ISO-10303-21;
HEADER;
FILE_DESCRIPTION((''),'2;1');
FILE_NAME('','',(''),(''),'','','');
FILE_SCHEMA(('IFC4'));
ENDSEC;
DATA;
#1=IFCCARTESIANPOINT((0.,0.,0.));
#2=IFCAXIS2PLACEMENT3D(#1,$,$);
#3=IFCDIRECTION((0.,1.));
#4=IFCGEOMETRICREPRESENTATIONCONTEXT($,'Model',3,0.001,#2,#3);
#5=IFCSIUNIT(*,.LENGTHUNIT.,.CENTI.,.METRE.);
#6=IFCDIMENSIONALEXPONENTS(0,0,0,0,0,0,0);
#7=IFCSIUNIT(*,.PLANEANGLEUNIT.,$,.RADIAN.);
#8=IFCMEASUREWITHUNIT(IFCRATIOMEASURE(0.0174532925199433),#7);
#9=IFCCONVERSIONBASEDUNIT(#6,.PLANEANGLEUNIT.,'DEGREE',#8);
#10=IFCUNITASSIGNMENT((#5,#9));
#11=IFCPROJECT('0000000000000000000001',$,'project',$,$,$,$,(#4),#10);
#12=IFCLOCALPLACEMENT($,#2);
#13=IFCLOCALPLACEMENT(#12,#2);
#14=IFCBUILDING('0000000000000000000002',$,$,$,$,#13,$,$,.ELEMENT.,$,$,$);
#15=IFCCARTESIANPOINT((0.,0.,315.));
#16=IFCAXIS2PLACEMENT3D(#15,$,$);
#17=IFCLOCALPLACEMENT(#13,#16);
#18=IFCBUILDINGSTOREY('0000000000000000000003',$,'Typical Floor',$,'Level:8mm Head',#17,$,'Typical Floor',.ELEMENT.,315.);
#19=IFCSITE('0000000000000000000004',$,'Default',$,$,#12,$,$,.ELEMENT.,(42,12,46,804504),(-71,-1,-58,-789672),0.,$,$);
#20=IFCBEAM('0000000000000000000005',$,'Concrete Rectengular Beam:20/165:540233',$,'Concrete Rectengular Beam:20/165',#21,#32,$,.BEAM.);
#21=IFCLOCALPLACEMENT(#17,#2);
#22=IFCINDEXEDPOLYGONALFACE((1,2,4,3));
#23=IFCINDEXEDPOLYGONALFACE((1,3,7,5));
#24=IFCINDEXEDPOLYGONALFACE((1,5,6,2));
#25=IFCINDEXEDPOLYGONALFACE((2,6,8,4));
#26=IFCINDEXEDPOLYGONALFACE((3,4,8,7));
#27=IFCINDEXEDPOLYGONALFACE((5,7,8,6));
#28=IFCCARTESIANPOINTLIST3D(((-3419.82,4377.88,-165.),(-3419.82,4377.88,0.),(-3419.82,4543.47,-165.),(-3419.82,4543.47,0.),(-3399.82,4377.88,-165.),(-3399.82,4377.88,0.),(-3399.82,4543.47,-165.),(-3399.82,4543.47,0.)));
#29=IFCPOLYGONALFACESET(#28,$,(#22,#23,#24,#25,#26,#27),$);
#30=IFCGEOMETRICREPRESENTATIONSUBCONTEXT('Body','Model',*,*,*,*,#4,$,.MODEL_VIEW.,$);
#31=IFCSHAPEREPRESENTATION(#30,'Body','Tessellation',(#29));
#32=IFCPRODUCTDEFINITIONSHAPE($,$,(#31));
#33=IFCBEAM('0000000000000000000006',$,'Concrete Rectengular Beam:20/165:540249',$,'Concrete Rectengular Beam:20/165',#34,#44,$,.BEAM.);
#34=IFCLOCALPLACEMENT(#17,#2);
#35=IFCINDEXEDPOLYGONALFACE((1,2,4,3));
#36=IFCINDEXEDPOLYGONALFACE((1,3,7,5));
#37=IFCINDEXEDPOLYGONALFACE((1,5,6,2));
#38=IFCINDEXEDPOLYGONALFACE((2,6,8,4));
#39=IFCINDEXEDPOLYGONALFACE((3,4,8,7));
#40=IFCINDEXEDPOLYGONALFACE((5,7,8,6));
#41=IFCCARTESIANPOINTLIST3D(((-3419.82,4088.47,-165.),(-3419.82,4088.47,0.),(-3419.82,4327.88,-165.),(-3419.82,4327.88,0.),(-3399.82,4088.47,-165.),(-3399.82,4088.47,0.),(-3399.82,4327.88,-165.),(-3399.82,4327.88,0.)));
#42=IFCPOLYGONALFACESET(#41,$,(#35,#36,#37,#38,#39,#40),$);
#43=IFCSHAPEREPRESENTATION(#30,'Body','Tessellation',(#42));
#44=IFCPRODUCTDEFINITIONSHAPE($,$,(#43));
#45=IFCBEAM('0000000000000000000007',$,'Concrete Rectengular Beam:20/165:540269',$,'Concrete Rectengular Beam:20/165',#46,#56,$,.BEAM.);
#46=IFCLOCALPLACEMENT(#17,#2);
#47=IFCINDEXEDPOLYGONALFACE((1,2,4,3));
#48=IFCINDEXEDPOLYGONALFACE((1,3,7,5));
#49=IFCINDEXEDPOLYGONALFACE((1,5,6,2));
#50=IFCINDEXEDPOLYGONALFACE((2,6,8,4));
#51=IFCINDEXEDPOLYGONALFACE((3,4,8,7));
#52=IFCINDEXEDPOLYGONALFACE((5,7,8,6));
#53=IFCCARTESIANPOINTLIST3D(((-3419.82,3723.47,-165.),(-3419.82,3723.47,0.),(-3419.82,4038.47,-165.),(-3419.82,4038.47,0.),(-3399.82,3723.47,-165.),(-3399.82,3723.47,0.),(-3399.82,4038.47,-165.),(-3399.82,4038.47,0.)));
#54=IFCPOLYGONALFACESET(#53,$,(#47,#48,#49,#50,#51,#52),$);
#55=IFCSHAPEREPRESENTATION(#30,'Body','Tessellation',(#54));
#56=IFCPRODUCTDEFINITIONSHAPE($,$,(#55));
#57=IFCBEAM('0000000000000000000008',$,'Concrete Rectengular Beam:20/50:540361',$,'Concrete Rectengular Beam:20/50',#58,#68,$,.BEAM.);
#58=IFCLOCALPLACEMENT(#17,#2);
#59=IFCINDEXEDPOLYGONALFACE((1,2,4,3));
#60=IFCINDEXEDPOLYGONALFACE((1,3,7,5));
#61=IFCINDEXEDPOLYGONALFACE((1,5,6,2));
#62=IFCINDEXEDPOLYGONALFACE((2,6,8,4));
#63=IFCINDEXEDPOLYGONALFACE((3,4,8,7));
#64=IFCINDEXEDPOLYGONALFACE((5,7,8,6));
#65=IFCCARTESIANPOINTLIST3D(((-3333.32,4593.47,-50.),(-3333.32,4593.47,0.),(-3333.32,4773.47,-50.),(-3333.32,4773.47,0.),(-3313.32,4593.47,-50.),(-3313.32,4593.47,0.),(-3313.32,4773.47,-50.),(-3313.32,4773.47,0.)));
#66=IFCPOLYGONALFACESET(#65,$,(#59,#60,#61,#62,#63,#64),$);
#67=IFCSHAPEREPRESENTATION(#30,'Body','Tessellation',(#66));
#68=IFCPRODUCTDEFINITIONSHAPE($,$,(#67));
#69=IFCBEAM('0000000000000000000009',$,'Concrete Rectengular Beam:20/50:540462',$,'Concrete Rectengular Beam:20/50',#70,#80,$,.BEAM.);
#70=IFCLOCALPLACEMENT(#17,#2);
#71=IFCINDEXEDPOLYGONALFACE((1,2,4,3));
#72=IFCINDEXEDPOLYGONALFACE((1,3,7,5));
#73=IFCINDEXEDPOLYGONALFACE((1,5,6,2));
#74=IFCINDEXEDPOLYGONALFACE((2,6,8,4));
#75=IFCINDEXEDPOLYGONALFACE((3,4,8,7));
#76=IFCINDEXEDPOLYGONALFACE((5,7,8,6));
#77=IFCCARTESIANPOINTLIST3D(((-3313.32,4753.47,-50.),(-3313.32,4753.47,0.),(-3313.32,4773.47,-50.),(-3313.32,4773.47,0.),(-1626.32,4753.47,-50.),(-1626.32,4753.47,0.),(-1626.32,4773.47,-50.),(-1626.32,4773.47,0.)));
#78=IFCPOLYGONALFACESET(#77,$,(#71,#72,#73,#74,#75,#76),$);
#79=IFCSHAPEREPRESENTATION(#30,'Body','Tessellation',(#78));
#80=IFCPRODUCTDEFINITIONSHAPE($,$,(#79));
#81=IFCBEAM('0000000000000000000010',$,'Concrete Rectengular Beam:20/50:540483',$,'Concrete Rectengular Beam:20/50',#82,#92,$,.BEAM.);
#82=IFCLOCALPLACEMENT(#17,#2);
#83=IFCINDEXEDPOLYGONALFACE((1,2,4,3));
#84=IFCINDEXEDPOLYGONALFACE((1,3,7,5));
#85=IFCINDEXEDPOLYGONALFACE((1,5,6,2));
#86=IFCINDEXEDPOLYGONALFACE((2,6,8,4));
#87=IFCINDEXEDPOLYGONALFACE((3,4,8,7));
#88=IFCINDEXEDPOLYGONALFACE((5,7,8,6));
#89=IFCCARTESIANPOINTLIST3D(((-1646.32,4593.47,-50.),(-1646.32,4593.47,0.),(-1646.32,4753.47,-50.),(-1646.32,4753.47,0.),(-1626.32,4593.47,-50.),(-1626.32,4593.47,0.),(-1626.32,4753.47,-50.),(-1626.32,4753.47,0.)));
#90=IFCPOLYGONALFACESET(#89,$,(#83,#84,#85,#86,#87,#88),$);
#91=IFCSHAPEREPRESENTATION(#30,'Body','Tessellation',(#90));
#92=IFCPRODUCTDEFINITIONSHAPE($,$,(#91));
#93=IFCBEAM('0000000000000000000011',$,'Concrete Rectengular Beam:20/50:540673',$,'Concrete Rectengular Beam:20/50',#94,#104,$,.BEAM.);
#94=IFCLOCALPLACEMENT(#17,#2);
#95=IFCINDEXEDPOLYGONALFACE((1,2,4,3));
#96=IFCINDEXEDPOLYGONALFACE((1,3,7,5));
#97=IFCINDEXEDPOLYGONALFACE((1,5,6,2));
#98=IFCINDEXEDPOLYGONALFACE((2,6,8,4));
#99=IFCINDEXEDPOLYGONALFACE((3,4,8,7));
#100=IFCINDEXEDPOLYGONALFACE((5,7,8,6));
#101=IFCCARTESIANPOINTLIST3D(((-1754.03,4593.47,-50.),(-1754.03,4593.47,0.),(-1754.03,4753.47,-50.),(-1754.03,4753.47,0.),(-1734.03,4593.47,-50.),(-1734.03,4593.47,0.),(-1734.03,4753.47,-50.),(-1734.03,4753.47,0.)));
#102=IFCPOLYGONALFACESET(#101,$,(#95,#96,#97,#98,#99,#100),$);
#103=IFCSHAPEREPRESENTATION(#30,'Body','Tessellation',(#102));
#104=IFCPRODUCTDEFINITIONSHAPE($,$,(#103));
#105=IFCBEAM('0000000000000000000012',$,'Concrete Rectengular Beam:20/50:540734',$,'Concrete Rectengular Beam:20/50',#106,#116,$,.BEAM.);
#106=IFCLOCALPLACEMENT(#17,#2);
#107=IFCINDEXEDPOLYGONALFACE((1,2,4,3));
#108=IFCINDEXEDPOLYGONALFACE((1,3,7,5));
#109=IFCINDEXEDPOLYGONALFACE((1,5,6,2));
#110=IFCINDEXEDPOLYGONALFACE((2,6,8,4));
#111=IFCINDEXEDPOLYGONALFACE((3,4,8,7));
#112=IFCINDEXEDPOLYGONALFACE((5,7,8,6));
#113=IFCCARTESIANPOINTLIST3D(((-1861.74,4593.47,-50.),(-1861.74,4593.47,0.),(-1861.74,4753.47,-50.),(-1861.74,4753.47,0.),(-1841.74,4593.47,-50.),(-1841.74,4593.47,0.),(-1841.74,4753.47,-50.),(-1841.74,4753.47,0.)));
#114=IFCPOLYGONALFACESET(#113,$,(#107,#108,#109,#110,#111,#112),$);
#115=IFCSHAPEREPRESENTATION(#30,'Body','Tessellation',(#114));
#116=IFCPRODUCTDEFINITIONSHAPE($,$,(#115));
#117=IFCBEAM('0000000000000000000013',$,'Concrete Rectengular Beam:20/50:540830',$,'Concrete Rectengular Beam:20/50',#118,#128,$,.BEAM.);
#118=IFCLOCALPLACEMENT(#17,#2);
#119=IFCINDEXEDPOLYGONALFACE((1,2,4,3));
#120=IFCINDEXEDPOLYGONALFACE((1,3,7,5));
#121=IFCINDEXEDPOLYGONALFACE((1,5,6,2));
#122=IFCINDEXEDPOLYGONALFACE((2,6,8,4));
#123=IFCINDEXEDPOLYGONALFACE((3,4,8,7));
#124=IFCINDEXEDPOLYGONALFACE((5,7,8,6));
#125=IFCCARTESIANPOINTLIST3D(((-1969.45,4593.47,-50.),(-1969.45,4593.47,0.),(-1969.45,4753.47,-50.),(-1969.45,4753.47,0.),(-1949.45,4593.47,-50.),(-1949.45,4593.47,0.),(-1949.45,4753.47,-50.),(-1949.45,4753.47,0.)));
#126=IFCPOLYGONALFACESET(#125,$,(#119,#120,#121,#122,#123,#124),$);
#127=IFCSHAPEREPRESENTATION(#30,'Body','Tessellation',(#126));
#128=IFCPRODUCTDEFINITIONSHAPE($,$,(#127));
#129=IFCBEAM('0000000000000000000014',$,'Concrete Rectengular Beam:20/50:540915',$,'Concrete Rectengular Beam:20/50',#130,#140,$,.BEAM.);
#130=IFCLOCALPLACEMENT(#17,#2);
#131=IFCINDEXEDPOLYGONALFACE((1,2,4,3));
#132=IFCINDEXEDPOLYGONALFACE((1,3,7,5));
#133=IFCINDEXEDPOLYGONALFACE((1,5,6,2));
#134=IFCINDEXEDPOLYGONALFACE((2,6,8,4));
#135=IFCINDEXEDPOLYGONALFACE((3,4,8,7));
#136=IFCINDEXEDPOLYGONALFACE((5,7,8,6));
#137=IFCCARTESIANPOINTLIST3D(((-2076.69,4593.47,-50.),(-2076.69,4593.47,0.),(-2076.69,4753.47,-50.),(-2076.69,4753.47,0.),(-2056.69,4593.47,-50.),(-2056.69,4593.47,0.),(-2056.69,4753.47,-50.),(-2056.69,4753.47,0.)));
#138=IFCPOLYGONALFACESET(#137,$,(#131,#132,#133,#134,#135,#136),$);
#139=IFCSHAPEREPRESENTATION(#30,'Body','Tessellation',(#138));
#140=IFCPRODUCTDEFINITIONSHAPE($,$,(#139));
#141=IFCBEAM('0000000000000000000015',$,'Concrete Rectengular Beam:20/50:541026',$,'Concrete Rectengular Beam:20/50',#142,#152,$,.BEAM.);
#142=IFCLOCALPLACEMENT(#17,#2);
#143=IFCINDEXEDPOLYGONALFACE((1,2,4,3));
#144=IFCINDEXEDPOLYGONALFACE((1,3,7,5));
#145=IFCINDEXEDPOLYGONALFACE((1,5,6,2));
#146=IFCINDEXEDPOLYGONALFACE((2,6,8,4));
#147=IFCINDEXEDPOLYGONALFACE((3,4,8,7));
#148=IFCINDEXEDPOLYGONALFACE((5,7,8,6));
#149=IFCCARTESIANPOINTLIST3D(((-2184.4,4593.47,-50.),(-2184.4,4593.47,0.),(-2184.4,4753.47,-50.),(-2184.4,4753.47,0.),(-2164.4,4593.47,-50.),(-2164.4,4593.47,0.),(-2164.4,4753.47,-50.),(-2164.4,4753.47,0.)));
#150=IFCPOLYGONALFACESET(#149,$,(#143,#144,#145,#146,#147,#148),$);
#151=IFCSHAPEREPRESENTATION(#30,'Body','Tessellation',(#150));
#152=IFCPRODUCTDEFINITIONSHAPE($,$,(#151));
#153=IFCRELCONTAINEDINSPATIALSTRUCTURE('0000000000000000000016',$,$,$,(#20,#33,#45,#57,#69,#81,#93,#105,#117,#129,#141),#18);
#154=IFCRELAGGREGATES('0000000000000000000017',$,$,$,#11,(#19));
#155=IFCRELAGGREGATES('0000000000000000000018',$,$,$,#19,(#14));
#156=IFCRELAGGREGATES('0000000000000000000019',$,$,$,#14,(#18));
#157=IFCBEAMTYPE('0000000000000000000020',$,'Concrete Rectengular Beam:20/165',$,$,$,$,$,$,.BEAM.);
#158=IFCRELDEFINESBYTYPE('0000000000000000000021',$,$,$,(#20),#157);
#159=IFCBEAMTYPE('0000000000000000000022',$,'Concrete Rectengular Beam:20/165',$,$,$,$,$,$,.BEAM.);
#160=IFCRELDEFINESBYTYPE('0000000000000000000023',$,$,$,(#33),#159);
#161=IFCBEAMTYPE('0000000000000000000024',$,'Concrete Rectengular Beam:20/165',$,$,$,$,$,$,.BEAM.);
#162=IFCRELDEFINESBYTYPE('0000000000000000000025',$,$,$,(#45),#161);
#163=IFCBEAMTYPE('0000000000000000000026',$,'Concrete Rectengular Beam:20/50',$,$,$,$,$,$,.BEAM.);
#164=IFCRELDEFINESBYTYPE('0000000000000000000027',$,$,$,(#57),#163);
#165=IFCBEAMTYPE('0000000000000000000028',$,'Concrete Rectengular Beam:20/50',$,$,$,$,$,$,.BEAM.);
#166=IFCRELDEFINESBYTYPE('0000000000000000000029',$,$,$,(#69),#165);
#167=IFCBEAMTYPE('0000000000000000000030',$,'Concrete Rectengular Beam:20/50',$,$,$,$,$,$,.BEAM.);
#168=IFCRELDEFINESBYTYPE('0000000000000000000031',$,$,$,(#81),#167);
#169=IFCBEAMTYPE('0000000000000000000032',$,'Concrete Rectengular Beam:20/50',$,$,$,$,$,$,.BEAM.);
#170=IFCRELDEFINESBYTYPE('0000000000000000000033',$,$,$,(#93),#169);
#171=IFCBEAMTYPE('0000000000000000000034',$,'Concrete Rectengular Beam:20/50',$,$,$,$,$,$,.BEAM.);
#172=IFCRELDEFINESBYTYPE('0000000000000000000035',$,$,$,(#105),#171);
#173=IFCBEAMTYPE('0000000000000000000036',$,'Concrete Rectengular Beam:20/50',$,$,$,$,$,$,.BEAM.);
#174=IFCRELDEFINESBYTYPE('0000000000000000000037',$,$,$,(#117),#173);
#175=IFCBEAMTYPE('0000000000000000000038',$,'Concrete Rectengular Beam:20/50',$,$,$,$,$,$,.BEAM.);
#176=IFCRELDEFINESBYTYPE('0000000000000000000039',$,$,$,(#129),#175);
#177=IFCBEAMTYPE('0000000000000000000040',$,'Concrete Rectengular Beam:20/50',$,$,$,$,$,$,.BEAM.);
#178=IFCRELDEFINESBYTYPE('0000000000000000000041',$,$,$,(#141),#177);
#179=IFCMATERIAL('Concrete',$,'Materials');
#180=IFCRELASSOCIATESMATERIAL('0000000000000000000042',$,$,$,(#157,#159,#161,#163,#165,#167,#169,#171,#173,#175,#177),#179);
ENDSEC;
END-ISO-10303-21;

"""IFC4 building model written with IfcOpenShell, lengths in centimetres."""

from ifc_helpers import new_model, entity, si_unit, converted_unit, direction, frame, origin, place, context, subcontext, project, spatial, indexed_curve, outline, extrude, source, transform, mapped, material, type_object, type_shapes, element, save


model = new_model("IFC4")

# Units and contexts
model_context = context("Model", 3, precision=0.001, world=origin(), true_north=direction((0.0, 1.0)))
body_context = subcontext(model_context, "Body", "Model", "MODEL_VIEW")
ifc_project = project(units=[si_unit("LENGTHUNIT", "METRE", prefix="CENTI"), converted_unit("PLANEANGLEUNIT", "DEGREE", entity("IfcRatioMeasure", 0.0174532925199433), si_unit("PLANEANGLEUNIT", "RADIAN"), dimensions=[0, 0, 0, 0, 0, 0, 0])], contexts=[model_context])

# Site, building, storey
site_placement = place(None, origin())
site = spatial("IfcSite", under=ifc_project, at=site_placement, Name="Default", CompositionType="ELEMENT", RefLatitude=(42, 12, 46, 804504), RefLongitude=(-71, -1, -58, -789672), RefElevation=0.0)
building_placement = place(site_placement, origin())
building = spatial("IfcBuilding", under=site, at=building_placement, CompositionType="ELEMENT")
storey_placement = place(building_placement, frame((0.0, 0.0, 315.0)))
storey = spatial("IfcBuildingStorey", under=building, at=storey_placement, Name="Typical Floor", ObjectType="Level:8mm Head", LongName="Typical Floor", CompositionType="ELEMENT", Elevation=315.0)

# Beams
ifc_material = material(Name="Concrete", Category="Materials")
beam_type_1 = type_object("IfcBeamType", Name="Concrete Rectengular Beam:20/165", PredefinedType="BEAM", material=ifc_material)
shared_shape_1 = source(origin(), body_context, "Body", "SweptSolid", [
    extrude(outline(indexed_curve([(-10.0, -82.5), (10.0, -82.5), (10.0, 82.5), (-10.0, 82.5), (-10.0, -82.5)], self_intersect=False)), frame((-3409.82, 4543.47, 232.5), z_axis=(0.0, -1.0, 0.0), x_axis=(-1.0, 0.0, 0.0)), (0.0, 0.0, 1.0), 165.59),
])
type_shapes(beam_type_1, [shared_shape_1])
beam_1_placement = place(storey_placement, frame((0.0, 0.0, -315.0)))
element("IfcBeam", 1, at=beam_1_placement, inside=storey, type_object=beam_type_1, Name="Concrete Rectengular Beam:20/165:540233", ObjectType="Concrete Rectengular Beam:20/165", PredefinedType="BEAM", context=body_context, shape_type="MappedRepresentation", body=[
    mapped(shared_shape_1, transform((0.0, 0.0, 0.0), scale=1.0)),
])
beam_type_2 = type_object("IfcBeamType", Name="Concrete Rectengular Beam:20/165", PredefinedType="BEAM", material=ifc_material)
shared_shape_2 = source(origin(), body_context, "Body", "SweptSolid", [
    extrude(outline(indexed_curve([(-10.0, -82.5), (10.0, -82.5), (10.0, 82.5), (-10.0, 82.5), (-10.0, -82.5)], self_intersect=False)), frame((-3409.82, 4327.88, 232.5), z_axis=(0.0, -1.0, 0.0), x_axis=(-1.0, 0.0, 0.0)), (0.0, 0.0, 1.0), 239.41),
])
type_shapes(beam_type_2, [shared_shape_2])
beam_2_placement = place(storey_placement, frame((0.0, 0.0, -315.0)))
element("IfcBeam", 2, at=beam_2_placement, inside=storey, type_object=beam_type_2, Name="Concrete Rectengular Beam:20/165:540249", ObjectType="Concrete Rectengular Beam:20/165", PredefinedType="BEAM", context=body_context, shape_type="MappedRepresentation", body=[
    mapped(shared_shape_2, transform((0.0, 0.0, 0.0), scale=1.0)),
])
beam_type_3 = type_object("IfcBeamType", Name="Concrete Rectengular Beam:20/165", PredefinedType="BEAM", material=ifc_material)
shared_shape_3 = source(origin(), body_context, "Body", "SweptSolid", [
    extrude(outline(indexed_curve([(-10.0, -82.5), (10.0, -82.5), (10.0, 82.5), (-10.0, 82.5), (-10.0, -82.5)], self_intersect=False)), frame((-3409.82, 4038.47, 232.5), z_axis=(0.0, -1.0, 0.0), x_axis=(-1.0, 0.0, 0.0)), (0.0, 0.0, 1.0), 315.0),
])
type_shapes(beam_type_3, [shared_shape_3])
beam_3_placement = place(storey_placement, frame((0.0, 0.0, -315.0)))
element("IfcBeam", 3, at=beam_3_placement, inside=storey, type_object=beam_type_3, Name="Concrete Rectengular Beam:20/165:540269", ObjectType="Concrete Rectengular Beam:20/165", PredefinedType="BEAM", context=body_context, shape_type="MappedRepresentation", body=[
    mapped(shared_shape_3, transform((0.0, 0.0, 0.0), scale=1.0)),
])
beam_type_4 = type_object("IfcBeamType", Name="Concrete Rectengular Beam:20/50", PredefinedType="BEAM", material=ifc_material)
shared_shape_4 = source(origin(), body_context, "Body", "SweptSolid", [
    extrude(outline(indexed_curve([(-10.0, -25.0), (10.0, -25.0), (10.0, 25.0), (-10.0, 25.0), (-10.0, -25.0)], self_intersect=False)), frame((-3323.32, 4593.47, 290.0), z_axis=(0.0, 1.0, 0.0), x_axis=(-1.0, 0.0, 0.0)), (0.0, 0.0, 1.0), 180.0),
])
type_shapes(beam_type_4, [shared_shape_4])
beam_4_placement = place(storey_placement, frame((0.0, 0.0, -315.0)))
element("IfcBeam", 4, at=beam_4_placement, inside=storey, type_object=beam_type_4, Name="Concrete Rectengular Beam:20/50:540361", ObjectType="Concrete Rectengular Beam:20/50", PredefinedType="BEAM", context=body_context, shape_type="MappedRepresentation", body=[
    mapped(shared_shape_4, transform((0.0, 0.0, 0.0), scale=1.0)),
])
beam_type_5 = type_object("IfcBeamType", Name="Concrete Rectengular Beam:20/50", PredefinedType="BEAM", material=ifc_material)
shared_shape_5 = source(origin(), body_context, "Body", "SweptSolid", [
    extrude(outline(indexed_curve([(-25.0, -10.0), (25.0, -10.0), (25.0, 10.0), (-25.0, 10.0), (-25.0, -10.0)], self_intersect=False)), frame((-3313.32, 4763.47, 290.0), z_axis=(1.0, 0.0, 0.0), x_axis=(0.0, 0.0, -1.0)), (0.0, 0.0, 1.0), 1687.0),
])
type_shapes(beam_type_5, [shared_shape_5])
beam_5_placement = place(storey_placement, frame((0.0, 0.0, -315.0)))
element("IfcBeam", 5, at=beam_5_placement, inside=storey, type_object=beam_type_5, Name="Concrete Rectengular Beam:20/50:540462", ObjectType="Concrete Rectengular Beam:20/50", PredefinedType="BEAM", context=body_context, shape_type="MappedRepresentation", body=[
    mapped(shared_shape_5, transform((0.0, 0.0, 0.0), scale=1.0)),
])
beam_type_6 = type_object("IfcBeamType", Name="Concrete Rectengular Beam:20/50", PredefinedType="BEAM", material=ifc_material)
shared_shape_6 = source(origin(), body_context, "Body", "SweptSolid", [
    extrude(outline(indexed_curve([(-10.0, -25.0), (10.0, -25.0), (10.0, 25.0), (-10.0, 25.0), (-10.0, -25.0)], self_intersect=False)), frame((-1636.32, 4753.47, 290.0), z_axis=(0.0, -1.0, 0.0), x_axis=(-1.0, 0.0, 0.0)), (0.0, 0.0, 1.0), 160.0),
])
type_shapes(beam_type_6, [shared_shape_6])
beam_6_placement = place(storey_placement, frame((0.0, 0.0, -315.0)))
element("IfcBeam", 6, at=beam_6_placement, inside=storey, type_object=beam_type_6, Name="Concrete Rectengular Beam:20/50:540483", ObjectType="Concrete Rectengular Beam:20/50", PredefinedType="BEAM", context=body_context, shape_type="MappedRepresentation", body=[
    mapped(shared_shape_6, transform((0.0, 0.0, 0.0), scale=1.0)),
])
beam_type_7 = type_object("IfcBeamType", Name="Concrete Rectengular Beam:20/50", PredefinedType="BEAM", material=ifc_material)
shared_shape_7 = source(origin(), body_context, "Body", "SweptSolid", [
    extrude(outline(indexed_curve([(-10.0, -25.0), (10.0, -25.0), (10.0, 25.0), (-10.0, 25.0), (-10.0, -25.0)], self_intersect=False)), frame((-1744.03, 4753.47, 290.0), z_axis=(0.0, -1.0, 0.0), x_axis=(-1.0, 0.0, 0.0)), (0.0, 0.0, 1.0), 160.0),
])
type_shapes(beam_type_7, [shared_shape_7])
beam_7_placement = place(storey_placement, frame((0.0, 0.0, -315.0)))
element("IfcBeam", 7, at=beam_7_placement, inside=storey, type_object=beam_type_7, Name="Concrete Rectengular Beam:20/50:540673", ObjectType="Concrete Rectengular Beam:20/50", PredefinedType="BEAM", context=body_context, shape_type="MappedRepresentation", body=[
    mapped(shared_shape_7, transform((0.0, 0.0, 0.0), scale=1.0)),
])
beam_type_8 = type_object("IfcBeamType", Name="Concrete Rectengular Beam:20/50", PredefinedType="BEAM", material=ifc_material)
shared_shape_8 = source(origin(), body_context, "Body", "SweptSolid", [
    extrude(outline(indexed_curve([(-10.0, -25.0), (10.0, -25.0), (10.0, 25.0), (-10.0, 25.0), (-10.0, -25.0)], self_intersect=False)), frame((-1851.74, 4753.47, 290.0), z_axis=(0.0, -1.0, 0.0), x_axis=(-1.0, 0.0, 0.0)), (0.0, 0.0, 1.0), 160.0),
])
type_shapes(beam_type_8, [shared_shape_8])
beam_8_placement = place(storey_placement, frame((0.0, 0.0, -315.0)))
element("IfcBeam", 8, at=beam_8_placement, inside=storey, type_object=beam_type_8, Name="Concrete Rectengular Beam:20/50:540734", ObjectType="Concrete Rectengular Beam:20/50", PredefinedType="BEAM", context=body_context, shape_type="MappedRepresentation", body=[
    mapped(shared_shape_8, transform((0.0, 0.0, 0.0), scale=1.0)),
])
beam_type_9 = type_object("IfcBeamType", Name="Concrete Rectengular Beam:20/50", PredefinedType="BEAM", material=ifc_material)
shared_shape_9 = source(origin(), body_context, "Body", "SweptSolid", [
    extrude(outline(indexed_curve([(-10.0, -25.0), (10.0, -25.0), (10.0, 25.0), (-10.0, 25.0), (-10.0, -25.0)], self_intersect=False)), frame((-1959.45, 4753.47, 290.0), z_axis=(0.0, -1.0, 0.0), x_axis=(-1.0, 0.0, 0.0)), (0.0, 0.0, 1.0), 160.0),
])
type_shapes(beam_type_9, [shared_shape_9])
beam_9_placement = place(storey_placement, frame((0.0, 0.0, -315.0)))
element("IfcBeam", 9, at=beam_9_placement, inside=storey, type_object=beam_type_9, Name="Concrete Rectengular Beam:20/50:540830", ObjectType="Concrete Rectengular Beam:20/50", PredefinedType="BEAM", context=body_context, shape_type="MappedRepresentation", body=[
    mapped(shared_shape_9, transform((0.0, 0.0, 0.0), scale=1.0)),
])
beam_type_10 = type_object("IfcBeamType", Name="Concrete Rectengular Beam:20/50", PredefinedType="BEAM", material=ifc_material)
shared_shape_10 = source(origin(), body_context, "Body", "SweptSolid", [
    extrude(outline(indexed_curve([(-10.0, -25.0), (10.0, -25.0), (10.0, 25.0), (-10.0, 25.0), (-10.0, -25.0)], self_intersect=False)), frame((-2066.69, 4753.47, 290.0), z_axis=(0.0, -1.0, 0.0), x_axis=(-1.0, 0.0, 0.0)), (0.0, 0.0, 1.0), 160.0),
])
type_shapes(beam_type_10, [shared_shape_10])
beam_10_placement = place(storey_placement, frame((0.0, 0.0, -315.0)))
element("IfcBeam", 10, at=beam_10_placement, inside=storey, type_object=beam_type_10, Name="Concrete Rectengular Beam:20/50:540915", ObjectType="Concrete Rectengular Beam:20/50", PredefinedType="BEAM", context=body_context, shape_type="MappedRepresentation", body=[
    mapped(shared_shape_10, transform((0.0, 0.0, 0.0), scale=1.0)),
])
beam_type_11 = type_object("IfcBeamType", Name="Concrete Rectengular Beam:20/50", PredefinedType="BEAM", material=ifc_material)
shared_shape_11 = source(origin(), body_context, "Body", "SweptSolid", [
    extrude(outline(indexed_curve([(-10.0, -25.0), (10.0, -25.0), (10.0, 25.0), (-10.0, 25.0), (-10.0, -25.0)], self_intersect=False)), frame((-2174.4, 4753.47, 290.0), z_axis=(0.0, -1.0, 0.0), x_axis=(-1.0, 0.0, 0.0)), (0.0, 0.0, 1.0), 160.0),
])
type_shapes(beam_type_11, [shared_shape_11])
beam_11_placement = place(storey_placement, frame((0.0, 0.0, -315.0)))
element("IfcBeam", 11, at=beam_11_placement, inside=storey, type_object=beam_type_11, Name="Concrete Rectengular Beam:20/50:541026", ObjectType="Concrete Rectengular Beam:20/50", PredefinedType="BEAM", context=body_context, shape_type="MappedRepresentation", body=[
    mapped(shared_shape_11, transform((0.0, 0.0, 0.0), scale=1.0)),
])

save(model, "model.ifc")
